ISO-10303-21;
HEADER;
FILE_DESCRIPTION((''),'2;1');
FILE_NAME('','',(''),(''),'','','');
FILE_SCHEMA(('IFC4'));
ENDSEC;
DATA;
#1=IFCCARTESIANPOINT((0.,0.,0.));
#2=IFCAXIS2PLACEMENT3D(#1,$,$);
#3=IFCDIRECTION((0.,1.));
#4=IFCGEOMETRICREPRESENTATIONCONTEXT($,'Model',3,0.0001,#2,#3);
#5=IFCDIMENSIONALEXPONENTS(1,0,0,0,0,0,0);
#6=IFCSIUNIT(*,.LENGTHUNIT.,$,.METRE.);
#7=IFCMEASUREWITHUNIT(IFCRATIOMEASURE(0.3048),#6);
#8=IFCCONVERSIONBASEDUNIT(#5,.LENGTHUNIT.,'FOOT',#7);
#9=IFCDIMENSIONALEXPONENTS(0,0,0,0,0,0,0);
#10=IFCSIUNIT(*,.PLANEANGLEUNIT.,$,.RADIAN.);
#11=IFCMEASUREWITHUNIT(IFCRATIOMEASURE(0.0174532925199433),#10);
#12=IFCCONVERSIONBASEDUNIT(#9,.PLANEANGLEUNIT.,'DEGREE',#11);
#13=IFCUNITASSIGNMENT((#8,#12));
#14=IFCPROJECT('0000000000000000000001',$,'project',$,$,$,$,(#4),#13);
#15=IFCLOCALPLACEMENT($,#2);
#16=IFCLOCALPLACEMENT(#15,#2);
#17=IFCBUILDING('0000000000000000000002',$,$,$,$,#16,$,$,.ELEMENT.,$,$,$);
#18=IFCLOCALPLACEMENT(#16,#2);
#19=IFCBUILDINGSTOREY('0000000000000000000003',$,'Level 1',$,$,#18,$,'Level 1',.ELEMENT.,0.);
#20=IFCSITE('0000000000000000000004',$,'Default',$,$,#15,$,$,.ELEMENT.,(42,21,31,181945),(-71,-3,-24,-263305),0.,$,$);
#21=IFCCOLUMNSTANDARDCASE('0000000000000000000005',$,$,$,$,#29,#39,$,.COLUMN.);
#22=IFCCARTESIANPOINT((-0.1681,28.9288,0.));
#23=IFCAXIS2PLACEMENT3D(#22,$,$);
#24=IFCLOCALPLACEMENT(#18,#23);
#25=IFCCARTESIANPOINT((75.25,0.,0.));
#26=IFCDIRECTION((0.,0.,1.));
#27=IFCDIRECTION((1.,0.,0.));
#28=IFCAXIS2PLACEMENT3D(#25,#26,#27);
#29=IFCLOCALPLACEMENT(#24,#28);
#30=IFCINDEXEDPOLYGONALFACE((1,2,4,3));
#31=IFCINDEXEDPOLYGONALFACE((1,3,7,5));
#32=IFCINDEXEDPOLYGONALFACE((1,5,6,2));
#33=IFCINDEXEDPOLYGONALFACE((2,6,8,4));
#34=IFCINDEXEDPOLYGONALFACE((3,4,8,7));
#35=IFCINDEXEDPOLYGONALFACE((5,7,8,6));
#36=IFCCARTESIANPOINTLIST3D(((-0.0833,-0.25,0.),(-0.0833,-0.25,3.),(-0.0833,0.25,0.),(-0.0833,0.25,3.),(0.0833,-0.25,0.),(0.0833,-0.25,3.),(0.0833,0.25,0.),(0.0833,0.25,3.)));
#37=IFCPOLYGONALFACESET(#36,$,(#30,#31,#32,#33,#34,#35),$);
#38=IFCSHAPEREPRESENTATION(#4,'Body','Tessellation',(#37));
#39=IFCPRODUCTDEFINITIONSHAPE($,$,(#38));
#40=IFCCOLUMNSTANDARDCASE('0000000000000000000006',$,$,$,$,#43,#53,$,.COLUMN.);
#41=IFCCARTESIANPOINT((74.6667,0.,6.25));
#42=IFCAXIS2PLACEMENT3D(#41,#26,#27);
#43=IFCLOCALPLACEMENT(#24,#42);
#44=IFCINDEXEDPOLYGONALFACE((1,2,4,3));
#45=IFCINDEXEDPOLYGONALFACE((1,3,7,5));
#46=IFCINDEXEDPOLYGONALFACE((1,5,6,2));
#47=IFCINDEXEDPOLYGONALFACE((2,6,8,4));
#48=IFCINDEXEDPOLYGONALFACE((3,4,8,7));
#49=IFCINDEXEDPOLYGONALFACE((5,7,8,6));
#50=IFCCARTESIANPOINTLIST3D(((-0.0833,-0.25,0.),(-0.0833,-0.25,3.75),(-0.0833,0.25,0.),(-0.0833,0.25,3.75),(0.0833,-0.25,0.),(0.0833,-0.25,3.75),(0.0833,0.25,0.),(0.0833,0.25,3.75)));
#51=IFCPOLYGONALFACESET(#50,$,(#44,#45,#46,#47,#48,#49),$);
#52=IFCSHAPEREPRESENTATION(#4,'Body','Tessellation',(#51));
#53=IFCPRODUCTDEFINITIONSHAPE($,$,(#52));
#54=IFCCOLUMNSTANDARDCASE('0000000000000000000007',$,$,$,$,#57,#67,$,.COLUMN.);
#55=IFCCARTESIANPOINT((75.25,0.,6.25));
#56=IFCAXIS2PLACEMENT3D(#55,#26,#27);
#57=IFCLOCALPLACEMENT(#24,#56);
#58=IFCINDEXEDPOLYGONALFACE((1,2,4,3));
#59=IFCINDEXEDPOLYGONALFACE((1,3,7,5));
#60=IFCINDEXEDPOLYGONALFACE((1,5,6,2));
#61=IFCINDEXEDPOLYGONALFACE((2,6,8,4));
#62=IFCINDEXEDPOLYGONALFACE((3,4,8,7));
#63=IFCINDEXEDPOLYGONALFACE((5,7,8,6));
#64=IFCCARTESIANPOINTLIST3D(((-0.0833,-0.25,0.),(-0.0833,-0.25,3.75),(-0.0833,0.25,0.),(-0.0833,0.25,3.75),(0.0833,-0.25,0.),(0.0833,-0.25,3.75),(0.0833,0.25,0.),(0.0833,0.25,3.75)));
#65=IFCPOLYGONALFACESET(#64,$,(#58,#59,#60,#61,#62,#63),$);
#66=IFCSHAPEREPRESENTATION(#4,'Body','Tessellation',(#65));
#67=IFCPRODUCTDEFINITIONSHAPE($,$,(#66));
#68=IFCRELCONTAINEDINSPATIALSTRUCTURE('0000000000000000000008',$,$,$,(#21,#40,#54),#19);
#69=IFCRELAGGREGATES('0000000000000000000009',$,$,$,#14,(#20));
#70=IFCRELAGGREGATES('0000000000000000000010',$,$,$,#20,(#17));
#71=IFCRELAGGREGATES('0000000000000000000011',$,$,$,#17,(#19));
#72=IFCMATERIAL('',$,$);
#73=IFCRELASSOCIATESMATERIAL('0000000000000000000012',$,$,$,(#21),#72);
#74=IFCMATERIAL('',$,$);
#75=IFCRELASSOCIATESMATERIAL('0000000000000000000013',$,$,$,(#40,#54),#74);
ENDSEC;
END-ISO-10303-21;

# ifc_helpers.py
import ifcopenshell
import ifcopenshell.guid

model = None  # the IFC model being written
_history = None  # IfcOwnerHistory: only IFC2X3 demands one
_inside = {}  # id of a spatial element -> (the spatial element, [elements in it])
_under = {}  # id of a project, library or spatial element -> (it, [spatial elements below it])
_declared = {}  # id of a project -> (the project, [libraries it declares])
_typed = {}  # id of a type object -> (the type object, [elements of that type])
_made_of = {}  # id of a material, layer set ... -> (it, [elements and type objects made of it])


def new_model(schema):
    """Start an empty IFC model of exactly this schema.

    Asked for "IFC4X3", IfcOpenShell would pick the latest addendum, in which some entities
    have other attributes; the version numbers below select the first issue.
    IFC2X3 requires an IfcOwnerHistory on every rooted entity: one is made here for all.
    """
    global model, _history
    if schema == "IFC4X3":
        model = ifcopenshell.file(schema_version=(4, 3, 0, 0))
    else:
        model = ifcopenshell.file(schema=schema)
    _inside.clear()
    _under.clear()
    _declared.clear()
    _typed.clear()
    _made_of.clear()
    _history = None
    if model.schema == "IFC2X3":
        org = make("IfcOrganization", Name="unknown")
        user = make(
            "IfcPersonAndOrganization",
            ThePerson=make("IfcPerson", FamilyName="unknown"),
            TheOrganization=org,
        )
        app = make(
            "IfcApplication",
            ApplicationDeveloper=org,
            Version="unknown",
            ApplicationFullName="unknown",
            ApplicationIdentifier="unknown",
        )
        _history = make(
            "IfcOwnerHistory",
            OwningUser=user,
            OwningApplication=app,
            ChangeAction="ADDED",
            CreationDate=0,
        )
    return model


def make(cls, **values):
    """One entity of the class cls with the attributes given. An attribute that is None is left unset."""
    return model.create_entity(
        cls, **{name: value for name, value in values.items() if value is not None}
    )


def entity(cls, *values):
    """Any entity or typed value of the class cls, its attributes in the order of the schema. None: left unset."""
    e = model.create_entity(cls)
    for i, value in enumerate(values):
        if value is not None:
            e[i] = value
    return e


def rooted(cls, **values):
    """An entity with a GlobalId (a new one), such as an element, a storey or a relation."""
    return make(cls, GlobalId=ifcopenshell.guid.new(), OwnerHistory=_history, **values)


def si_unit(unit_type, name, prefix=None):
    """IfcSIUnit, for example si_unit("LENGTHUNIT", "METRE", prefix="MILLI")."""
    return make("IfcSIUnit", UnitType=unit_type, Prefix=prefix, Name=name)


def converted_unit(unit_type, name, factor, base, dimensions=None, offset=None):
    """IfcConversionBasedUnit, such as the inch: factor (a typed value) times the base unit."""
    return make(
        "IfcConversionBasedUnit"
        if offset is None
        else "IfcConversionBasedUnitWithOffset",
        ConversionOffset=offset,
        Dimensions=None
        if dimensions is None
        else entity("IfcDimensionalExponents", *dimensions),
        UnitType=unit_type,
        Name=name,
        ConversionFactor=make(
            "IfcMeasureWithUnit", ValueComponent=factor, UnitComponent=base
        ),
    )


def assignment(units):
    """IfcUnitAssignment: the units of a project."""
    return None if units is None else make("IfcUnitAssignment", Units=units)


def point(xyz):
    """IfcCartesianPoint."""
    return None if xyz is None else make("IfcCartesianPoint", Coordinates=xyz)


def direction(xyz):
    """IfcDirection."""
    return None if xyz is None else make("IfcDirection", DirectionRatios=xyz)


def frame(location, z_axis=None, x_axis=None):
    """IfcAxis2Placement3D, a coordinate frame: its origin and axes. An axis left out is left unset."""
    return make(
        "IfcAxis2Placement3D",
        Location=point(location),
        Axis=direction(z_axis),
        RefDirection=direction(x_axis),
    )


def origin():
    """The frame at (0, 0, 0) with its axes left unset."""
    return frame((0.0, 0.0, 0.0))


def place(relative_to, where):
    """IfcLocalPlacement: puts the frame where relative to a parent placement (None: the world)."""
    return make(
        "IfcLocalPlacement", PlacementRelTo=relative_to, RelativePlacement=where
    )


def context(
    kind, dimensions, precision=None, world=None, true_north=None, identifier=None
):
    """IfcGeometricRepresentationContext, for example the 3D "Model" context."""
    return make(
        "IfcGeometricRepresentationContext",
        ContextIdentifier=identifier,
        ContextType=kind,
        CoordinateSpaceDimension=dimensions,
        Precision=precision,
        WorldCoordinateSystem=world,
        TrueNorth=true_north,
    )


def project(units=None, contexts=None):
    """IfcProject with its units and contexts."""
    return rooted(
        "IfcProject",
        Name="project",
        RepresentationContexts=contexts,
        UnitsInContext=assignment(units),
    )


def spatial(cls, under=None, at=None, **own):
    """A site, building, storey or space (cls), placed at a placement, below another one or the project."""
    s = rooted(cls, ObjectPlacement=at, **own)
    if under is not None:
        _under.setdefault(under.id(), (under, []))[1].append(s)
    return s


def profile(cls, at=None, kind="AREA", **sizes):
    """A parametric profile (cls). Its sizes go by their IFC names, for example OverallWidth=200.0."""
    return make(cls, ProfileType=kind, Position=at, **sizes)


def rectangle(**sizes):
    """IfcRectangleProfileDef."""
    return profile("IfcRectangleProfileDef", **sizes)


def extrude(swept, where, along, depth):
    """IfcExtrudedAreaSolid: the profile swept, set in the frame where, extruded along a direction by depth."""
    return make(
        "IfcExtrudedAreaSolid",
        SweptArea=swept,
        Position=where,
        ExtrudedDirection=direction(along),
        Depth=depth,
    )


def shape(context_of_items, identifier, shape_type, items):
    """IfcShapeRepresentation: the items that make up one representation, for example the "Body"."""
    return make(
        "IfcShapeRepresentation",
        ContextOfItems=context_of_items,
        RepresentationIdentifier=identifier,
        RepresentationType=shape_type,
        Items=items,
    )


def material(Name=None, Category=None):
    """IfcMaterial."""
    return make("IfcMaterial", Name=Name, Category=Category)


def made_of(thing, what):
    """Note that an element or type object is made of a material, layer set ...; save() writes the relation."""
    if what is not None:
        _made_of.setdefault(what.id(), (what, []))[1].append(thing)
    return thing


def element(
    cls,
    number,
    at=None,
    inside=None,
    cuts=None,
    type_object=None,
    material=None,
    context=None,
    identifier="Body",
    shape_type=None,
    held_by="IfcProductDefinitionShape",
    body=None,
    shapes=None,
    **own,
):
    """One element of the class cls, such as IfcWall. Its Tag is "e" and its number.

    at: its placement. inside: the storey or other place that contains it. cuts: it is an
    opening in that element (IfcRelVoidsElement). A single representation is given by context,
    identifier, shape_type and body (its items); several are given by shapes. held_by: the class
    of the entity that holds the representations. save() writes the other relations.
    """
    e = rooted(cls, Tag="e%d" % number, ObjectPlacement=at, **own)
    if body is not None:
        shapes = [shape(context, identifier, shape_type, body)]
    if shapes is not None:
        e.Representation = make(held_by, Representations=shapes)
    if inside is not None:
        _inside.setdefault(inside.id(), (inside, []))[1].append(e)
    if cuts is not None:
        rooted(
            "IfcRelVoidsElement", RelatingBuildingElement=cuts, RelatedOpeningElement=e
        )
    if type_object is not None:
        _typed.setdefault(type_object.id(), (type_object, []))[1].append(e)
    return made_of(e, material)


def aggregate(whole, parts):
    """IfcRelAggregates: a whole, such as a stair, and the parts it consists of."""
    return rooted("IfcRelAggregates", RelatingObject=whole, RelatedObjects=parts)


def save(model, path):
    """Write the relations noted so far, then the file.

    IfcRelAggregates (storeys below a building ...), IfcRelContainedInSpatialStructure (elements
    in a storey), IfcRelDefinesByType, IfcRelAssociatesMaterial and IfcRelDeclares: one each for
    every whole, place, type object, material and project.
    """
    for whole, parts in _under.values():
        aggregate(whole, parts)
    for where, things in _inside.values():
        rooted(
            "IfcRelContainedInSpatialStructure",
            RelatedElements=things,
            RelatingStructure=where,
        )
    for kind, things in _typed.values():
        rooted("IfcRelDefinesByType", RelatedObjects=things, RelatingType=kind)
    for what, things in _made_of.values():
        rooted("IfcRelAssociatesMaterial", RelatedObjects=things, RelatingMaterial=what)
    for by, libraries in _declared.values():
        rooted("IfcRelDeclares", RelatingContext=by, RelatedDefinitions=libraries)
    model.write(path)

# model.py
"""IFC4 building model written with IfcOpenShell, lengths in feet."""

from ifc_helpers import new_model, entity, si_unit, converted_unit, direction, frame, origin, place, context, project, spatial, rectangle, extrude, material, element, save


model = new_model("IFC4")

# Units and contexts
model_context = context("Model", 3, precision=0.0001, world=origin(), true_north=direction((0.0, 1.0)))
ifc_project = project(units=[converted_unit("LENGTHUNIT", "FOOT", entity("IfcRatioMeasure", 0.3048), si_unit("LENGTHUNIT", "METRE"), dimensions=[1, 0, 0, 0, 0, 0, 0]), converted_unit("PLANEANGLEUNIT", "DEGREE", entity("IfcRatioMeasure", 0.0174532925199433), si_unit("PLANEANGLEUNIT", "RADIAN"), dimensions=[0, 0, 0, 0, 0, 0, 0])], contexts=[model_context])

# Site, building, storey
site_placement = place(None, origin())
site = spatial("IfcSite", under=ifc_project, at=site_placement, Name="Default", CompositionType="ELEMENT", RefLatitude=(42, 21, 31, 181945), RefLongitude=(-71, -3, -24, -263305), RefElevation=0.0)
building_placement = place(site_placement, origin())
building = spatial("IfcBuilding", under=site, at=building_placement, CompositionType="ELEMENT")
storey_placement = place(building_placement, origin())
storey = spatial("IfcBuildingStorey", under=building, at=storey_placement, Name="Level 1", LongName="Level 1", CompositionType="ELEMENT", Elevation=0.0)

# Columns
ifc_material_1 = material(Name="")
placement = place(storey_placement, frame((-0.1681, 28.9288, 0.0)))
for number, where, z_axis, x_axis in (
    (1, (75.25, 0.0, 0.0), (0.0, 0.0, 1.0), (1.0, 0.0, 0.0)),
):
    element("IfcColumnStandardCase", number, at=place(placement, frame(where, z_axis=z_axis, x_axis=x_axis)), inside=storey, material=ifc_material_1, PredefinedType="COLUMN", context=model_context, shape_type="SweptSolid", body=[
        extrude(rectangle(XDim=0.1667, YDim=0.5), origin(), (0.0, 0.0, 1.0), 3.0),
    ])
ifc_material_2 = material(Name="")
for number, where, z_axis, x_axis in (
    (2, (74.6667, 0.0, 6.25), (0.0, 0.0, 1.0), (1.0, 0.0, 0.0)),
    (3, (75.25, 0.0, 6.25), (0.0, 0.0, 1.0), (1.0, 0.0, 0.0)),
):
    element("IfcColumnStandardCase", number, at=place(placement, frame(where, z_axis=z_axis, x_axis=x_axis)), inside=storey, material=ifc_material_2, PredefinedType="COLUMN", context=model_context, shape_type="SweptSolid", body=[
        extrude(rectangle(XDim=0.1667, YDim=0.5), origin(), (0.0, 0.0, 1.0), 3.75),
    ])

save(model, "model.ifc")
